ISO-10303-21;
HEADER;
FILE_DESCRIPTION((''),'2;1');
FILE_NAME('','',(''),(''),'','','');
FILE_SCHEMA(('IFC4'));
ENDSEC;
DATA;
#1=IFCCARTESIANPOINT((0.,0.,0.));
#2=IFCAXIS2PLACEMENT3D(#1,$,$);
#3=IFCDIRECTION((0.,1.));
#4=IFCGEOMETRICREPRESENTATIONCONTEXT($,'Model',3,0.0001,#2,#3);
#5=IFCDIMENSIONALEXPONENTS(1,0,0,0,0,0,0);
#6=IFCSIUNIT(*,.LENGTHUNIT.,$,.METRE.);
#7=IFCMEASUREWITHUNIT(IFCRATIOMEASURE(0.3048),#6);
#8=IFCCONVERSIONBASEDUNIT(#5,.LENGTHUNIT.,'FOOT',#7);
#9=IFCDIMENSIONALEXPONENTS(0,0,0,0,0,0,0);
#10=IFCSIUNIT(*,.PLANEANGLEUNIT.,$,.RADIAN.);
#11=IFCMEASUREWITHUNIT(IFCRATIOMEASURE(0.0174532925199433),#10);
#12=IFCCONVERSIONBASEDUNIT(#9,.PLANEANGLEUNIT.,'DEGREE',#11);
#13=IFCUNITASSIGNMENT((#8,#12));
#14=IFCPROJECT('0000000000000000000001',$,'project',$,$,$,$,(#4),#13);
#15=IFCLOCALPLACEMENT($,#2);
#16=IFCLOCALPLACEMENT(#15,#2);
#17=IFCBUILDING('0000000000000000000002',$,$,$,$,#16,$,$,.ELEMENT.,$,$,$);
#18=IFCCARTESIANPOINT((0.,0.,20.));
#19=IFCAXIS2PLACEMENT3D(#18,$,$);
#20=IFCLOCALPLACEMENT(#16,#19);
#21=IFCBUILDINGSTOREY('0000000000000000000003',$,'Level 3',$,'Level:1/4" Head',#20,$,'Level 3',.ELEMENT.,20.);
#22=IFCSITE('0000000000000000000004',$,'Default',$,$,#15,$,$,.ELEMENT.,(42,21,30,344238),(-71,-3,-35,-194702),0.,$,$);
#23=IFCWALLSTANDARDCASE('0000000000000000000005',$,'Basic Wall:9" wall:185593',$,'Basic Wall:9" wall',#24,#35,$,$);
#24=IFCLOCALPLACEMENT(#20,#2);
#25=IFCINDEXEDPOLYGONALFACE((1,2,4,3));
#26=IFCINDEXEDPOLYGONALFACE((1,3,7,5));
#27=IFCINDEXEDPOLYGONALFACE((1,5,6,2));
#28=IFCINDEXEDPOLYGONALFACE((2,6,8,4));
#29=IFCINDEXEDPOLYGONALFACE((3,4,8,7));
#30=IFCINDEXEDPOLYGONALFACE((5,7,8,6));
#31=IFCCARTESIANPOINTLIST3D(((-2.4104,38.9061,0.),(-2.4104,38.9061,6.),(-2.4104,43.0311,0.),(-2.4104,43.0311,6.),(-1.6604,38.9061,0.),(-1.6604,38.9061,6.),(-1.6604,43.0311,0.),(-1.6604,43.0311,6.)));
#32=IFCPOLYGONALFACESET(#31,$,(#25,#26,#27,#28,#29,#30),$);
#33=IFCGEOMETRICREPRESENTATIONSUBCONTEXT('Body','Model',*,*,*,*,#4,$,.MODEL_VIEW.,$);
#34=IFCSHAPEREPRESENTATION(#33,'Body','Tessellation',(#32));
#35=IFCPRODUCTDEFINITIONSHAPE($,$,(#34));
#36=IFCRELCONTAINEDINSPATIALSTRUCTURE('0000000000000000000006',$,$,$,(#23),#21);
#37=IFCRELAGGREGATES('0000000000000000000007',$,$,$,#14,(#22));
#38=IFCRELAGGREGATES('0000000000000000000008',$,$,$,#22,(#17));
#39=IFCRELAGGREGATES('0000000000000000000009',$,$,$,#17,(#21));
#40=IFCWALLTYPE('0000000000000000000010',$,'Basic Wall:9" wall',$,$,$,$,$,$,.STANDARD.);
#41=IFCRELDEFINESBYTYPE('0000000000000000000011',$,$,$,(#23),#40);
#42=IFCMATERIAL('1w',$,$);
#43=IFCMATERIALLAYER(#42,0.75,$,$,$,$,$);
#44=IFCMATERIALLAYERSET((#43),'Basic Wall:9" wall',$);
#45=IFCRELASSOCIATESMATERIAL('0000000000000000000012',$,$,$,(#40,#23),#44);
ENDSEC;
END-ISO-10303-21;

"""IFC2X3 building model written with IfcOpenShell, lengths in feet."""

from ifc_helpers import new_model, entity, si_unit, converted_unit, direction, frame, frame_2d, origin, place, context, subcontext, project, spatial, rectangle, extrude, material, layer, layer_set, layer_usage, type_object, element, save


model = new_model("IFC2X3")

# Units and contexts
model_context = context("Model", 3, precision=0.0001, world=origin(), true_north=direction((0.0, 1.0)))
body_context = subcontext(model_context, "Body", "Model", "MODEL_VIEW")
ifc_project = project(units=[converted_unit("LENGTHUNIT", "FOOT", entity("IfcRatioMeasure", 0.3048), si_unit("LENGTHUNIT", "METRE"), dimensions=[1, 0, 0, 0, 0, 0, 0]), converted_unit("PLANEANGLEUNIT", "DEGREE", entity("IfcRatioMeasure", 0.0174532925199433), si_unit("PLANEANGLEUNIT", "RADIAN"), dimensions=[0, 0, 0, 0, 0, 0, 0])], contexts=[model_context])

# Site, building, storey
site_placement = place(None, origin())
site = spatial("IfcSite", under=ifc_project, at=site_placement, Name="Default", CompositionType="ELEMENT", RefLatitude=(42, 21, 30, 344238), RefLongitude=(-71, -3, -35, -194702), RefElevation=0.0)
building_placement = place(site_placement, origin())
building = spatial("IfcBuilding", under=site, at=building_placement, CompositionType="ELEMENT")
storey_placement = place(building_placement, frame((0.0, 0.0, 20.0)))
storey = spatial("IfcBuildingStorey", under=building, at=storey_placement, Name="Level 3", ObjectType="Level:1/4\" Head", LongName="Level 3", CompositionType="ELEMENT", Elevation=20.0)

# Shared definitions
ifc_material = material(Name="1w")

# Shared definitions
ifc_layer_1 = layer(ifc_material, 0.75)
ifc_layer_set_1 = layer_set([ifc_layer_1], Name="Basic Wall:9\" wall")
wall_type = type_object("IfcWallType", Name="Basic Wall:9\" wall", PredefinedType="STANDARD", material=ifc_layer_set_1)

# Wall
ifc_layer_usage_1 = layer_usage(ifc_layer_set_1, "AXIS2", "NEGATIVE", 0.375)
wall_1_placement = place(storey_placement, frame((-2.0354, 38.9061, 0.0), z_axis=(0.0, 0.0, 1.0), x_axis=(0.0, 1.0, 0.0)))
element("IfcWallStandardCase", 1, at=wall_1_placement, inside=storey, type_object=wall_type, material=ifc_layer_usage_1, Name="Basic Wall:9\" wall:185593", ObjectType="Basic Wall:9\" wall", context=body_context, shape_type="SweptSolid", body=[
    extrude(rectangle(XDim=4.125, YDim=0.75, at=frame_2d((2.0625, 0.0), x_axis=(-1.0, 0.0))), origin(), (0.0, 0.0, 1.0), 6.0),
])

save(model, "model.ifc")
